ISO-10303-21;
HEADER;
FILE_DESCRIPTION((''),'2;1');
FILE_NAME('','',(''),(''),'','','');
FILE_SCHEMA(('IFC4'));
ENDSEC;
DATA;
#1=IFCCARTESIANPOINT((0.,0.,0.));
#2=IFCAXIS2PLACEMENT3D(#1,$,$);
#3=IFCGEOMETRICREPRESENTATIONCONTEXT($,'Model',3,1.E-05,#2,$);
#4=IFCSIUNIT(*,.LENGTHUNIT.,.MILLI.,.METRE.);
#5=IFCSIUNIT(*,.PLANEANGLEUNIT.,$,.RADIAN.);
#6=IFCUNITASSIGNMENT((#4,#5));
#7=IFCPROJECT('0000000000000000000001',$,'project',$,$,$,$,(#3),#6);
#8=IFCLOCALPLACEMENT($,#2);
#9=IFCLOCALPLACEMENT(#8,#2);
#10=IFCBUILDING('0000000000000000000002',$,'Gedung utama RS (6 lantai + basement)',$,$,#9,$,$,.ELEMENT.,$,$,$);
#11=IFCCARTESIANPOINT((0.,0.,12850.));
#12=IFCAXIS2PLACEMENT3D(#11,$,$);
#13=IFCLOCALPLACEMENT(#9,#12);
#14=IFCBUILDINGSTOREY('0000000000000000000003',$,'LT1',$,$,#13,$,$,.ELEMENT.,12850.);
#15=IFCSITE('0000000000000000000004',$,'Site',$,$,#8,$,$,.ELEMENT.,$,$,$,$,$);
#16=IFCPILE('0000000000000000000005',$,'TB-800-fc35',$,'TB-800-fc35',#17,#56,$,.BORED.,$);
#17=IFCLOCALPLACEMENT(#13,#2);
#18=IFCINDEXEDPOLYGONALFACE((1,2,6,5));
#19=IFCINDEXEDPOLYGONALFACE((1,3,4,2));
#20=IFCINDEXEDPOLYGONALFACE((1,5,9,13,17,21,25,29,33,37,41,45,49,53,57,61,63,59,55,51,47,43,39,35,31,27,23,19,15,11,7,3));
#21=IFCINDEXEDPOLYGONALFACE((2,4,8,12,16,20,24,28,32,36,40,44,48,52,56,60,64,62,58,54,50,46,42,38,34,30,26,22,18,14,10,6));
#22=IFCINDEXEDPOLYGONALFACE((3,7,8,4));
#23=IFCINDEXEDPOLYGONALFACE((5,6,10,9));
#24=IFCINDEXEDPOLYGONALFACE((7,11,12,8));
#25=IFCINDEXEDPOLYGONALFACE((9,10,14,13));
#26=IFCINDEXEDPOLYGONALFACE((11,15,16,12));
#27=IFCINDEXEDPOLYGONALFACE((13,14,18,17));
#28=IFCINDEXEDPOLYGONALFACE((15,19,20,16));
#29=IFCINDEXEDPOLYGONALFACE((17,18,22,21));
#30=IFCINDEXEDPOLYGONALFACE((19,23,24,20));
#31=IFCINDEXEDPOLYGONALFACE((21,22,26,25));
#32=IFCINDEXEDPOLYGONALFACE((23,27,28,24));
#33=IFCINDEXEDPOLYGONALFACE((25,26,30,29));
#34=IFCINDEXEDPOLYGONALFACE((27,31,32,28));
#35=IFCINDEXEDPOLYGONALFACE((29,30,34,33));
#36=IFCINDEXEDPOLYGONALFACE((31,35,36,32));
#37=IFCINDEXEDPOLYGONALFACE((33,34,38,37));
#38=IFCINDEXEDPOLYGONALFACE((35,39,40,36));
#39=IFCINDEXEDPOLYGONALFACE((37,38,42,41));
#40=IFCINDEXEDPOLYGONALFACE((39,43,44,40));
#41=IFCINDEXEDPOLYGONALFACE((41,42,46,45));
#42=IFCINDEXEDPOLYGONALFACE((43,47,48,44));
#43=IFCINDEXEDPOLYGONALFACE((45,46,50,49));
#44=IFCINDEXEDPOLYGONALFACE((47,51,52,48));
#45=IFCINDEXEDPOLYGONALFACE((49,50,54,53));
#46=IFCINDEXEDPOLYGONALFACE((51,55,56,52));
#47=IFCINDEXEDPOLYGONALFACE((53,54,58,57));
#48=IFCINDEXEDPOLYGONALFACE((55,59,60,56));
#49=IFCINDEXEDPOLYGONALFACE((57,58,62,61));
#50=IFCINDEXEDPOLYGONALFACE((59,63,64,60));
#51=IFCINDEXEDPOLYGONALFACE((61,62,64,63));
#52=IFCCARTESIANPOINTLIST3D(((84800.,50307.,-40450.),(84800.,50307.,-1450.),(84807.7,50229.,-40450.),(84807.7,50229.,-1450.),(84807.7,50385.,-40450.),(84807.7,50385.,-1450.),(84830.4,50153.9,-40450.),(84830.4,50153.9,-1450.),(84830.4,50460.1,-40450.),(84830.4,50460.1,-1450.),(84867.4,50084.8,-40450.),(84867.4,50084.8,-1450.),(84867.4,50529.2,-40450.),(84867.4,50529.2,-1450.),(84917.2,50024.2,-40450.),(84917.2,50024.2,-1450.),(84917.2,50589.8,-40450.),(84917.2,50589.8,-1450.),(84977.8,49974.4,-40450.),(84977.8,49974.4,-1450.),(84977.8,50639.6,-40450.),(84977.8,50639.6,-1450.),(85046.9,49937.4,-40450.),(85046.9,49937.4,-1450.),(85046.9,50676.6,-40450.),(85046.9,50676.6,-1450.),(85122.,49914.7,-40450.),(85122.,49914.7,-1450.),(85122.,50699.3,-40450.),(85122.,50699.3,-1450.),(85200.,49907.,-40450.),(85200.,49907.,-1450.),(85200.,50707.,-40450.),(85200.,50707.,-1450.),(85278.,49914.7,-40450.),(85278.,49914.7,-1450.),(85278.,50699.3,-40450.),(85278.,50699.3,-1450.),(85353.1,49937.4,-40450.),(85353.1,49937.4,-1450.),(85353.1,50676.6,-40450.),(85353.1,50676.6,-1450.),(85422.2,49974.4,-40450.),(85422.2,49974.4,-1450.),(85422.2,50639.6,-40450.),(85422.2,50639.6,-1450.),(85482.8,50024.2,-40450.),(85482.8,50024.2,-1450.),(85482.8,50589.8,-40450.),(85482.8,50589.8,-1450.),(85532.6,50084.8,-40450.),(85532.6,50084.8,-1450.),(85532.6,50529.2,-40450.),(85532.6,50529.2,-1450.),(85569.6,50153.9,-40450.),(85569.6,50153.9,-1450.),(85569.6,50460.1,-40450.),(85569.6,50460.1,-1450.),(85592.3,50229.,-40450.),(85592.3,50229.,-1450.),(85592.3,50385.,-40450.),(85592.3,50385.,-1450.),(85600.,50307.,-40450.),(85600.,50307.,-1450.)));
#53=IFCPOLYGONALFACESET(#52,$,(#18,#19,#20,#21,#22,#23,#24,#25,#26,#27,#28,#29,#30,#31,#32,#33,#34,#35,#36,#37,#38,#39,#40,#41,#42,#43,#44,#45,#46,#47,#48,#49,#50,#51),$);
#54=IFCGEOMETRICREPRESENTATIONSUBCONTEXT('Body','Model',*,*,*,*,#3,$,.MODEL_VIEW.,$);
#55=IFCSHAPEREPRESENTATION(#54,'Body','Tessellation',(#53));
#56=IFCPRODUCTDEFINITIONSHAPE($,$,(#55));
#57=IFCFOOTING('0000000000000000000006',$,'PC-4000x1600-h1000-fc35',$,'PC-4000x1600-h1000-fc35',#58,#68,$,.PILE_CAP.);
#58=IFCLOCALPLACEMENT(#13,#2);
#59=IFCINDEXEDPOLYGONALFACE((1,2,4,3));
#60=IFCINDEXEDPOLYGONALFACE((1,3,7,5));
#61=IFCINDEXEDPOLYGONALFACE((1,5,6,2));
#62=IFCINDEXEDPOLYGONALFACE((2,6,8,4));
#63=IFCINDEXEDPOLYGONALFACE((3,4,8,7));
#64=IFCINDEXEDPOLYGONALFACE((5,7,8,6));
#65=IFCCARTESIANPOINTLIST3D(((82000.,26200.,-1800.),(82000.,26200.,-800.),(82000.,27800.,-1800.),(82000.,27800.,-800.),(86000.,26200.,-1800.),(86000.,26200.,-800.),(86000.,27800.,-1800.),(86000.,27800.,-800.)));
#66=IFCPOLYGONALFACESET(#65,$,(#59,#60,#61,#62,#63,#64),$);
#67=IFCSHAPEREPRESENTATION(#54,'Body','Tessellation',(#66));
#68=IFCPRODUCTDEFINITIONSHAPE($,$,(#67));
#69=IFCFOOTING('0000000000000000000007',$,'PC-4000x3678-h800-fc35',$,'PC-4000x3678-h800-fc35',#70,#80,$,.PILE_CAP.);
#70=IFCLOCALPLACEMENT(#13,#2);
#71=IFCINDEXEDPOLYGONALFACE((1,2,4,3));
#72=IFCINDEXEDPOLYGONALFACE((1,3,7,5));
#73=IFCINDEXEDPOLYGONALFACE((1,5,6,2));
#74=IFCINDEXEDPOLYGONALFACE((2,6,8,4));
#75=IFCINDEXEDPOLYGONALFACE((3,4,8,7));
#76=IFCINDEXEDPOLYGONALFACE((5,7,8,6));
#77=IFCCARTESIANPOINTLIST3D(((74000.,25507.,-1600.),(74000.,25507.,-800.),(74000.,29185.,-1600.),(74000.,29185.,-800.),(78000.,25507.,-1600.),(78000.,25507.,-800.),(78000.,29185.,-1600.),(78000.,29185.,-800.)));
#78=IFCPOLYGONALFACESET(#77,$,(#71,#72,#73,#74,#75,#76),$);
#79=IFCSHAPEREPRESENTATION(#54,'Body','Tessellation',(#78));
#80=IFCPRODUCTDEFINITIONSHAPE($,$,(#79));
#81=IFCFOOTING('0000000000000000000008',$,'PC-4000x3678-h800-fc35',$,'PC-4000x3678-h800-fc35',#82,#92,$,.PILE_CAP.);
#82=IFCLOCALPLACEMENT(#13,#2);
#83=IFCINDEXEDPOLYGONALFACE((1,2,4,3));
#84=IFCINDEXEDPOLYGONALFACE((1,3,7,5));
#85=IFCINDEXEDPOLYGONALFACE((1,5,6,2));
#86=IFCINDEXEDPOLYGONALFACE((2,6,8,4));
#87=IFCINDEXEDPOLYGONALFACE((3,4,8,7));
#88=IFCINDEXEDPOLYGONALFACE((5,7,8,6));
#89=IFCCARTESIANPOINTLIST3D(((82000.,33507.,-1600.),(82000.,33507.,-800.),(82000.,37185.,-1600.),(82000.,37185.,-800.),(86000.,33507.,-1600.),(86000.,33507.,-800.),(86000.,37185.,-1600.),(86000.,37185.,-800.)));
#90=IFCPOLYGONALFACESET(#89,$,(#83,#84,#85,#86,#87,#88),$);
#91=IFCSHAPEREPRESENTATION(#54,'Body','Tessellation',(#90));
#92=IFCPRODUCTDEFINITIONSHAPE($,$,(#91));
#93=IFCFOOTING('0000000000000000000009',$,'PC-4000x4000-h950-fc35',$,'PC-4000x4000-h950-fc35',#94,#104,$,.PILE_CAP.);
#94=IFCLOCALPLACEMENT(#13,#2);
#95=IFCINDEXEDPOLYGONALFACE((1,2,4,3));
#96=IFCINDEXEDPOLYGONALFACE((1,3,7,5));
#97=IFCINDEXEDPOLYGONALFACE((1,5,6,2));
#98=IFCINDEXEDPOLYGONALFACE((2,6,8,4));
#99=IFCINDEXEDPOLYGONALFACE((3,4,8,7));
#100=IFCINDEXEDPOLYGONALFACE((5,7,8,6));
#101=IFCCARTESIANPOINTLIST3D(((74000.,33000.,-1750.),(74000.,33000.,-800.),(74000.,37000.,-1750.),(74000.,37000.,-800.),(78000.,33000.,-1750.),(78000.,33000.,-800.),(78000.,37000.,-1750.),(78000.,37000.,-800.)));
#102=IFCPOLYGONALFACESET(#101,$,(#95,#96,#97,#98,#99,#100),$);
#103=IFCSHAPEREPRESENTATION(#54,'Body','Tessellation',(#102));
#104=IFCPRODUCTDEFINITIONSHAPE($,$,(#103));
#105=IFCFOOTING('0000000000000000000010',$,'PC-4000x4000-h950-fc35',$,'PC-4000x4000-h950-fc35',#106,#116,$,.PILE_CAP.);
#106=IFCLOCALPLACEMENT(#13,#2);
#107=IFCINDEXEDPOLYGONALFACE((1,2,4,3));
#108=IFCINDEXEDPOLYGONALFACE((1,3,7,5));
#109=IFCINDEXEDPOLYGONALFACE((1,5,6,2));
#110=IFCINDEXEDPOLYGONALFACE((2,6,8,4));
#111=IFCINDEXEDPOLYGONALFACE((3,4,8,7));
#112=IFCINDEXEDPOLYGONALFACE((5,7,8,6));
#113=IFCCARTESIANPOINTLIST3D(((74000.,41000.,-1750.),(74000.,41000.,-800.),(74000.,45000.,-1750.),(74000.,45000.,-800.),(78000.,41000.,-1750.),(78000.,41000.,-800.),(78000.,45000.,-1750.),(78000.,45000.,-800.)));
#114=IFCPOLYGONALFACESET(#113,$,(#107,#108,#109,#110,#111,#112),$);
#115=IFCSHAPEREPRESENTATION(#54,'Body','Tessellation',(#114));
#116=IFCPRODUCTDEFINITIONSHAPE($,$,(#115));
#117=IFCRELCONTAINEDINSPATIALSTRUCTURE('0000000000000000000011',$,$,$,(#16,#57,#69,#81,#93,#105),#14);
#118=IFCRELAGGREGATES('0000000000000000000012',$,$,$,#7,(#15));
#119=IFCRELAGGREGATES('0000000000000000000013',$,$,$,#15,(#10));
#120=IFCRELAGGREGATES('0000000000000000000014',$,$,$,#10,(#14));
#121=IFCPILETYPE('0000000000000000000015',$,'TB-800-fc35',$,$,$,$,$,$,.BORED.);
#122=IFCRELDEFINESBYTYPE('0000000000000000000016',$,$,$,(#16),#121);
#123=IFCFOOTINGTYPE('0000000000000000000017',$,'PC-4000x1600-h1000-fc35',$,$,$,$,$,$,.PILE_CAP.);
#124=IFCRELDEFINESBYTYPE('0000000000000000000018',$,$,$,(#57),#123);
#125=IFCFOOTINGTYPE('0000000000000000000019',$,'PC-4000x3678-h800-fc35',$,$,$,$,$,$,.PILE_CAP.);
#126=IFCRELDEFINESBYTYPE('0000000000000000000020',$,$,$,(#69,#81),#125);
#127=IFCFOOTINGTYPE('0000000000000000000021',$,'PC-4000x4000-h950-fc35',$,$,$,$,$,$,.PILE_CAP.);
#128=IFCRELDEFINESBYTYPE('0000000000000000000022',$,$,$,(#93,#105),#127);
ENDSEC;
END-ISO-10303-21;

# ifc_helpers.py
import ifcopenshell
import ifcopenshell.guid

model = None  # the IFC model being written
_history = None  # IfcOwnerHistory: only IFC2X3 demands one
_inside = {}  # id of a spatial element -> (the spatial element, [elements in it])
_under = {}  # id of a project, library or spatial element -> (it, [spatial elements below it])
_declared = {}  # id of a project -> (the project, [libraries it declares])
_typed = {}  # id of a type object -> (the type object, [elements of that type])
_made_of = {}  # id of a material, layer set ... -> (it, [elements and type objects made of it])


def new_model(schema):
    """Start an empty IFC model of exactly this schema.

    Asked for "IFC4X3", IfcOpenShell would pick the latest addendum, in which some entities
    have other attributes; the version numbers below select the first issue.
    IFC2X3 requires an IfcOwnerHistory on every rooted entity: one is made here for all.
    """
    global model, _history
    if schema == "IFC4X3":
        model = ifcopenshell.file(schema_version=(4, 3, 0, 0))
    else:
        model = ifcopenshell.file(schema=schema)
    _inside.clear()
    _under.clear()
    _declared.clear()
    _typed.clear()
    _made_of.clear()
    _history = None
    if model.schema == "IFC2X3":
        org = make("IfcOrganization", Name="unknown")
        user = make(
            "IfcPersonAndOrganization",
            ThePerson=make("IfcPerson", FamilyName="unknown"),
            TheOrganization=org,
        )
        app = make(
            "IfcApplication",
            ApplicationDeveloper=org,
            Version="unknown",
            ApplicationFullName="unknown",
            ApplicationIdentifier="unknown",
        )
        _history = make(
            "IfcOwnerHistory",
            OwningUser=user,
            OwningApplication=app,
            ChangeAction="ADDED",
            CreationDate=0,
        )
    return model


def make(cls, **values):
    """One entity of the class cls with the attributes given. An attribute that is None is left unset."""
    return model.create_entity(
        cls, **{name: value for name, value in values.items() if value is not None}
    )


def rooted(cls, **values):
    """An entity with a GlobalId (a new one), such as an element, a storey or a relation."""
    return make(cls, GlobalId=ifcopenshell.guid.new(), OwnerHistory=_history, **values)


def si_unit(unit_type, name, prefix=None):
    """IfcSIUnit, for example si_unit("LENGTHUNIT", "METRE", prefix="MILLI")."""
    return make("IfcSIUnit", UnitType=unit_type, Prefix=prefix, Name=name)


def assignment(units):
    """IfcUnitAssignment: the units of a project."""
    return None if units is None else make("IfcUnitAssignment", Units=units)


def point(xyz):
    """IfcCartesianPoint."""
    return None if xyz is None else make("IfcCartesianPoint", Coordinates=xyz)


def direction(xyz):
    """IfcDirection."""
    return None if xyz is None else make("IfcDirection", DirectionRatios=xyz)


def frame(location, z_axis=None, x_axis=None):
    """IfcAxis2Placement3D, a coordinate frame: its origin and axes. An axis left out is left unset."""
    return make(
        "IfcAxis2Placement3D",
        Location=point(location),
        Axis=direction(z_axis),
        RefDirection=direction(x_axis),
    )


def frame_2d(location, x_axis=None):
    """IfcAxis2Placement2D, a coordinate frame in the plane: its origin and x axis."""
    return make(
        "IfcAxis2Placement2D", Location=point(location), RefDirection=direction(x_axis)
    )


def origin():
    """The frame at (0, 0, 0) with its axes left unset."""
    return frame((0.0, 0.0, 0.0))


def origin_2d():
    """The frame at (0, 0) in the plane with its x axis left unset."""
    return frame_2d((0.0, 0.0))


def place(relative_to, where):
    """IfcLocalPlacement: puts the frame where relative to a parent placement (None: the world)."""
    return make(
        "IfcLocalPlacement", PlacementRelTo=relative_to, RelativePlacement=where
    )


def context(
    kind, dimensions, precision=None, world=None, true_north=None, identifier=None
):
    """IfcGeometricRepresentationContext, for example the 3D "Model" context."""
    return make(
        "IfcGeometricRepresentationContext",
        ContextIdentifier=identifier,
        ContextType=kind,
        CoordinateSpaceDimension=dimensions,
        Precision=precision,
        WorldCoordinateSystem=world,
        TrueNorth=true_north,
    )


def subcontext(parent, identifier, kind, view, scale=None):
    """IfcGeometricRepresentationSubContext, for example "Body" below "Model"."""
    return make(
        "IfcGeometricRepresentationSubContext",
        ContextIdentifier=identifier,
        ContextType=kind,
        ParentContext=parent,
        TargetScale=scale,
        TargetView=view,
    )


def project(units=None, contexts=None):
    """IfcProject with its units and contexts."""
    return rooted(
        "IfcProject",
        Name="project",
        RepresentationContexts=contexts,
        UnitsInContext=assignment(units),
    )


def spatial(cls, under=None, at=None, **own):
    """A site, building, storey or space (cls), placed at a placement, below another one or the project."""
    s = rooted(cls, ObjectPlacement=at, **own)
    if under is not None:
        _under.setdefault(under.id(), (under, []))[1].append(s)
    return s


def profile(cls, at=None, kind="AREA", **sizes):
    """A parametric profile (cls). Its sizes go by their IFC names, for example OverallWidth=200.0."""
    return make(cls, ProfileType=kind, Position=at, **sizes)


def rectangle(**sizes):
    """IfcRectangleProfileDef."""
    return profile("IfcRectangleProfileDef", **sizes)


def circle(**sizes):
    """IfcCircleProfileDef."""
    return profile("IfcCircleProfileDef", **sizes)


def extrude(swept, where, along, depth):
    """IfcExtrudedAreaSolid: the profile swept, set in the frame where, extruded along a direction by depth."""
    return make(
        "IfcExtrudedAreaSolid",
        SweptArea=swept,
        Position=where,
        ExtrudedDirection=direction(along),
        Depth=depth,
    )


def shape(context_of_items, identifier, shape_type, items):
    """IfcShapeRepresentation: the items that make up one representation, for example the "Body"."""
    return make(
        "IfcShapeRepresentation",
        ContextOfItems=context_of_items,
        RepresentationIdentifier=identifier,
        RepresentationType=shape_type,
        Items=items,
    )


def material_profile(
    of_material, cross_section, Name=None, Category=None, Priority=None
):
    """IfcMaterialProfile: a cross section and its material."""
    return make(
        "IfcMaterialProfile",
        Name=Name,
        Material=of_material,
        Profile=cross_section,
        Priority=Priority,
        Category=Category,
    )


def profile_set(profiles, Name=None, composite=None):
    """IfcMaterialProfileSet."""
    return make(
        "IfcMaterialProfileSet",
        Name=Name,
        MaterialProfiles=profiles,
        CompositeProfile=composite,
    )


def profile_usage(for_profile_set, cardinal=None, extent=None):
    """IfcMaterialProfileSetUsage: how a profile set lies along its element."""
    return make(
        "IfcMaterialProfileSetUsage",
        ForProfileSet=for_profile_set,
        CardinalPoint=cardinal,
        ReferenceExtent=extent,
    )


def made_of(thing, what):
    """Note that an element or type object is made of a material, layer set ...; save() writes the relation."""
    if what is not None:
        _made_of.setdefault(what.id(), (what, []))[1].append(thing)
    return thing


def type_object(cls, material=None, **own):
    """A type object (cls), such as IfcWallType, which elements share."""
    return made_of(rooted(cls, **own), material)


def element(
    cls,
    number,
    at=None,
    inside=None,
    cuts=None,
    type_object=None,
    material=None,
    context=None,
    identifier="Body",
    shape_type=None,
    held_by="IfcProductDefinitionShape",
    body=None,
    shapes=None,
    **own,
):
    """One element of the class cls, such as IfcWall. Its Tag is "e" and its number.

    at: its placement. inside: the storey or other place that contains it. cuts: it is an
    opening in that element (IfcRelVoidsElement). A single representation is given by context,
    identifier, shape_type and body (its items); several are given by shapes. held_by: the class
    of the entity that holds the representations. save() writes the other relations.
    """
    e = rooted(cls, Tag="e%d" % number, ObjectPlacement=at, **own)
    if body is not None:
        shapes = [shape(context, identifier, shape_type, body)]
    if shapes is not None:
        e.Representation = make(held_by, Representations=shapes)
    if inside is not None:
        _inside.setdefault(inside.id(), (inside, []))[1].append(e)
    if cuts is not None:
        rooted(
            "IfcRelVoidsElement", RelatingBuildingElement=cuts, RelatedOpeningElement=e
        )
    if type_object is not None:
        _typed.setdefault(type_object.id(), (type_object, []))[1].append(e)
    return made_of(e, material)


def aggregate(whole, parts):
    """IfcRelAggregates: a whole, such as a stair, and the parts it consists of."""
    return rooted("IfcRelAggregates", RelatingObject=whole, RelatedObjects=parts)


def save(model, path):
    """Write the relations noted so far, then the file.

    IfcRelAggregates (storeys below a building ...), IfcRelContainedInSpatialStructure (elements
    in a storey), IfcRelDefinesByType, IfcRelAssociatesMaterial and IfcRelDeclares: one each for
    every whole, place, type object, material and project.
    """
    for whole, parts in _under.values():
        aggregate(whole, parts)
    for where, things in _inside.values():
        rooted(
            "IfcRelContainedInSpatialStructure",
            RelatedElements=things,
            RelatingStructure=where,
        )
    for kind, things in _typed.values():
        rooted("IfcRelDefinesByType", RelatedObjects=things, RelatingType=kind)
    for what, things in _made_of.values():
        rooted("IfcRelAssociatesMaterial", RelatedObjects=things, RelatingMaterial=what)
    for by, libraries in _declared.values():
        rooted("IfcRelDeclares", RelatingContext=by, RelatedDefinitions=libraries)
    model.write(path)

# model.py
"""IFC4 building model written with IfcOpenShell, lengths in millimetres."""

from ifc_helpers import new_model, si_unit, frame, origin, origin_2d, place, context, subcontext, project, spatial, rectangle, circle, extrude, material_profile, profile_set, profile_usage, type_object, element, save


model = new_model("IFC4")

# Units and contexts
model_context = context("Model", 3, precision=1e-05, world=origin())
body_context = subcontext(model_context, "Body", "Model", "MODEL_VIEW")
ifc_project = project(units=[si_unit("LENGTHUNIT", "METRE", prefix="MILLI"), si_unit("PLANEANGLEUNIT", "RADIAN")], contexts=[model_context])

# Site, building, storey
site_placement = place(None, origin())
site = spatial("IfcSite", under=ifc_project, at=site_placement, Name="Site", CompositionType="ELEMENT")
building_placement = place(site_placement, origin())
building = spatial("IfcBuilding", under=site, at=building_placement, Name="Gedung utama RS (6 lantai + basement)", CompositionType="ELEMENT")
storey_placement = place(building_placement, frame((0.0, 0.0, 12850.0)))
storey = spatial("IfcBuildingStorey", under=building, at=storey_placement, Name="LT1", CompositionType="ELEMENT", Elevation=12850.0)

# Pile
ifc_material_profile_1 = material_profile(None, circle(Radius=400.0, at=origin_2d()), Name="TB-800-fc35")
ifc_profile_set_1 = profile_set([ifc_material_profile_1], Name="TB-800-fc35")
ifc_profile_usage_1 = profile_usage(ifc_profile_set_1, cardinal=5)
pile_type = type_object("IfcPileType", Name="TB-800-fc35", PredefinedType="BORED", material=ifc_profile_set_1)
for number, where, z_axis, x_axis, name in (
    (1, (85200.0, 50307.0, -40450.0), (0.0, 0.0, 1.0), (1.0, 0.0, 0.0), "TB-800-fc35"),
):
    element("IfcPile", number, at=place(storey_placement, frame(where, z_axis=z_axis, x_axis=x_axis)), inside=storey, type_object=pile_type, material=ifc_profile_usage_1, Name=name, ObjectType="TB-800-fc35", PredefinedType="BORED", context=body_context, shape_type="SweptSolid", body=[
        extrude(circle(Radius=400.0, at=origin_2d()), origin(), (0.0, 0.0, 1.0), 39000.0),
    ])

# Footings
ifc_material_profile_2 = material_profile(None, rectangle(XDim=4000.0, YDim=1600.0, at=origin_2d()), Name="PC-4000x1600-h1000-fc35")
ifc_profile_set_2 = profile_set([ifc_material_profile_2], Name="PC-4000x1600-h1000-fc35")
ifc_profile_usage_2 = profile_usage(ifc_profile_set_2, cardinal=5)
footing_type_1 = type_object("IfcFootingType", Name="PC-4000x1600-h1000-fc35", PredefinedType="PILE_CAP", material=ifc_profile_set_2)
footing_placement = place(storey_placement, frame((84000.0, 27000.0, -1800.0), z_axis=(0.0, 0.0, 1.0), x_axis=(1.0, 0.0, 0.0)))
element("IfcFooting", 2, at=footing_placement, inside=storey, type_object=footing_type_1, material=ifc_profile_usage_2, Name="PC-4000x1600-h1000-fc35", ObjectType="PC-4000x1600-h1000-fc35", PredefinedType="PILE_CAP", context=body_context, shape_type="SweptSolid", body=[
    extrude(rectangle(XDim=4000.0, YDim=1600.0, at=origin_2d()), origin(), (0.0, 0.0, 1.0), 1000.0),
])
ifc_material_profile_3 = material_profile(None, rectangle(XDim=4000.0, YDim=3678.0, at=origin_2d()), Name="PC-4000x3678-h800-fc35")
ifc_profile_set_3 = profile_set([ifc_material_profile_3], Name="PC-4000x3678-h800-fc35")
ifc_profile_usage_3 = profile_usage(ifc_profile_set_3, cardinal=5)
footing_type_2 = type_object("IfcFootingType", Name="PC-4000x3678-h800-fc35", PredefinedType="PILE_CAP", material=ifc_profile_set_3)
for number, where, z_axis, x_axis, name in (
    (3, (76000.0, 27346.0, -1600.0), (0.0, 0.0, 1.0), (1.0, 0.0, 0.0), "PC-4000x3678-h800-fc35"),
    (4, (84000.0, 35346.0, -1600.0), (0.0, 0.0, 1.0), (1.0, 0.0, 0.0), "PC-4000x3678-h800-fc35"),
):
    element("IfcFooting", number, at=place(storey_placement, frame(where, z_axis=z_axis, x_axis=x_axis)), inside=storey, type_object=footing_type_2, material=ifc_profile_usage_3, Name=name, ObjectType="PC-4000x3678-h800-fc35", PredefinedType="PILE_CAP", context=body_context, shape_type="SweptSolid", body=[
        extrude(rectangle(XDim=4000.0, YDim=3678.0, at=origin_2d()), origin(), (0.0, 0.0, 1.0), 800.0),
    ])
ifc_material_profile_4 = material_profile(None, rectangle(XDim=4000.0, YDim=4000.0, at=origin_2d()), Name="PC-4000x4000-h950-fc35")
ifc_profile_set_4 = profile_set([ifc_material_profile_4], Name="PC-4000x4000-h950-fc35")
ifc_profile_usage_4 = profile_usage(ifc_profile_set_4, cardinal=5)
footing_type_3 = type_object("IfcFootingType", Name="PC-4000x4000-h950-fc35", PredefinedType="PILE_CAP", material=ifc_profile_set_4)
for number, where, z_axis, x_axis, name in (
    (5, (76000.0, 35000.0, -1750.0), (0.0, 0.0, 1.0), (1.0, 0.0, 0.0), "PC-4000x4000-h950-fc35"),
    (6, (76000.0, 43000.0, -1750.0), (0.0, 0.0, 1.0), (1.0, 0.0, 0.0), "PC-4000x4000-h950-fc35"),
):
    element("IfcFooting", number, at=place(storey_placement, frame(where, z_axis=z_axis, x_axis=x_axis)), inside=storey, type_object=footing_type_3, material=ifc_profile_usage_4, Name=name, ObjectType="PC-4000x4000-h950-fc35", PredefinedType="PILE_CAP", context=body_context, shape_type="SweptSolid", body=[
        extrude(rectangle(XDim=4000.0, YDim=4000.0, at=origin_2d()), origin(), (0.0, 0.0, 1.0), 950.0),
    ])

save(model, "model.ifc")
